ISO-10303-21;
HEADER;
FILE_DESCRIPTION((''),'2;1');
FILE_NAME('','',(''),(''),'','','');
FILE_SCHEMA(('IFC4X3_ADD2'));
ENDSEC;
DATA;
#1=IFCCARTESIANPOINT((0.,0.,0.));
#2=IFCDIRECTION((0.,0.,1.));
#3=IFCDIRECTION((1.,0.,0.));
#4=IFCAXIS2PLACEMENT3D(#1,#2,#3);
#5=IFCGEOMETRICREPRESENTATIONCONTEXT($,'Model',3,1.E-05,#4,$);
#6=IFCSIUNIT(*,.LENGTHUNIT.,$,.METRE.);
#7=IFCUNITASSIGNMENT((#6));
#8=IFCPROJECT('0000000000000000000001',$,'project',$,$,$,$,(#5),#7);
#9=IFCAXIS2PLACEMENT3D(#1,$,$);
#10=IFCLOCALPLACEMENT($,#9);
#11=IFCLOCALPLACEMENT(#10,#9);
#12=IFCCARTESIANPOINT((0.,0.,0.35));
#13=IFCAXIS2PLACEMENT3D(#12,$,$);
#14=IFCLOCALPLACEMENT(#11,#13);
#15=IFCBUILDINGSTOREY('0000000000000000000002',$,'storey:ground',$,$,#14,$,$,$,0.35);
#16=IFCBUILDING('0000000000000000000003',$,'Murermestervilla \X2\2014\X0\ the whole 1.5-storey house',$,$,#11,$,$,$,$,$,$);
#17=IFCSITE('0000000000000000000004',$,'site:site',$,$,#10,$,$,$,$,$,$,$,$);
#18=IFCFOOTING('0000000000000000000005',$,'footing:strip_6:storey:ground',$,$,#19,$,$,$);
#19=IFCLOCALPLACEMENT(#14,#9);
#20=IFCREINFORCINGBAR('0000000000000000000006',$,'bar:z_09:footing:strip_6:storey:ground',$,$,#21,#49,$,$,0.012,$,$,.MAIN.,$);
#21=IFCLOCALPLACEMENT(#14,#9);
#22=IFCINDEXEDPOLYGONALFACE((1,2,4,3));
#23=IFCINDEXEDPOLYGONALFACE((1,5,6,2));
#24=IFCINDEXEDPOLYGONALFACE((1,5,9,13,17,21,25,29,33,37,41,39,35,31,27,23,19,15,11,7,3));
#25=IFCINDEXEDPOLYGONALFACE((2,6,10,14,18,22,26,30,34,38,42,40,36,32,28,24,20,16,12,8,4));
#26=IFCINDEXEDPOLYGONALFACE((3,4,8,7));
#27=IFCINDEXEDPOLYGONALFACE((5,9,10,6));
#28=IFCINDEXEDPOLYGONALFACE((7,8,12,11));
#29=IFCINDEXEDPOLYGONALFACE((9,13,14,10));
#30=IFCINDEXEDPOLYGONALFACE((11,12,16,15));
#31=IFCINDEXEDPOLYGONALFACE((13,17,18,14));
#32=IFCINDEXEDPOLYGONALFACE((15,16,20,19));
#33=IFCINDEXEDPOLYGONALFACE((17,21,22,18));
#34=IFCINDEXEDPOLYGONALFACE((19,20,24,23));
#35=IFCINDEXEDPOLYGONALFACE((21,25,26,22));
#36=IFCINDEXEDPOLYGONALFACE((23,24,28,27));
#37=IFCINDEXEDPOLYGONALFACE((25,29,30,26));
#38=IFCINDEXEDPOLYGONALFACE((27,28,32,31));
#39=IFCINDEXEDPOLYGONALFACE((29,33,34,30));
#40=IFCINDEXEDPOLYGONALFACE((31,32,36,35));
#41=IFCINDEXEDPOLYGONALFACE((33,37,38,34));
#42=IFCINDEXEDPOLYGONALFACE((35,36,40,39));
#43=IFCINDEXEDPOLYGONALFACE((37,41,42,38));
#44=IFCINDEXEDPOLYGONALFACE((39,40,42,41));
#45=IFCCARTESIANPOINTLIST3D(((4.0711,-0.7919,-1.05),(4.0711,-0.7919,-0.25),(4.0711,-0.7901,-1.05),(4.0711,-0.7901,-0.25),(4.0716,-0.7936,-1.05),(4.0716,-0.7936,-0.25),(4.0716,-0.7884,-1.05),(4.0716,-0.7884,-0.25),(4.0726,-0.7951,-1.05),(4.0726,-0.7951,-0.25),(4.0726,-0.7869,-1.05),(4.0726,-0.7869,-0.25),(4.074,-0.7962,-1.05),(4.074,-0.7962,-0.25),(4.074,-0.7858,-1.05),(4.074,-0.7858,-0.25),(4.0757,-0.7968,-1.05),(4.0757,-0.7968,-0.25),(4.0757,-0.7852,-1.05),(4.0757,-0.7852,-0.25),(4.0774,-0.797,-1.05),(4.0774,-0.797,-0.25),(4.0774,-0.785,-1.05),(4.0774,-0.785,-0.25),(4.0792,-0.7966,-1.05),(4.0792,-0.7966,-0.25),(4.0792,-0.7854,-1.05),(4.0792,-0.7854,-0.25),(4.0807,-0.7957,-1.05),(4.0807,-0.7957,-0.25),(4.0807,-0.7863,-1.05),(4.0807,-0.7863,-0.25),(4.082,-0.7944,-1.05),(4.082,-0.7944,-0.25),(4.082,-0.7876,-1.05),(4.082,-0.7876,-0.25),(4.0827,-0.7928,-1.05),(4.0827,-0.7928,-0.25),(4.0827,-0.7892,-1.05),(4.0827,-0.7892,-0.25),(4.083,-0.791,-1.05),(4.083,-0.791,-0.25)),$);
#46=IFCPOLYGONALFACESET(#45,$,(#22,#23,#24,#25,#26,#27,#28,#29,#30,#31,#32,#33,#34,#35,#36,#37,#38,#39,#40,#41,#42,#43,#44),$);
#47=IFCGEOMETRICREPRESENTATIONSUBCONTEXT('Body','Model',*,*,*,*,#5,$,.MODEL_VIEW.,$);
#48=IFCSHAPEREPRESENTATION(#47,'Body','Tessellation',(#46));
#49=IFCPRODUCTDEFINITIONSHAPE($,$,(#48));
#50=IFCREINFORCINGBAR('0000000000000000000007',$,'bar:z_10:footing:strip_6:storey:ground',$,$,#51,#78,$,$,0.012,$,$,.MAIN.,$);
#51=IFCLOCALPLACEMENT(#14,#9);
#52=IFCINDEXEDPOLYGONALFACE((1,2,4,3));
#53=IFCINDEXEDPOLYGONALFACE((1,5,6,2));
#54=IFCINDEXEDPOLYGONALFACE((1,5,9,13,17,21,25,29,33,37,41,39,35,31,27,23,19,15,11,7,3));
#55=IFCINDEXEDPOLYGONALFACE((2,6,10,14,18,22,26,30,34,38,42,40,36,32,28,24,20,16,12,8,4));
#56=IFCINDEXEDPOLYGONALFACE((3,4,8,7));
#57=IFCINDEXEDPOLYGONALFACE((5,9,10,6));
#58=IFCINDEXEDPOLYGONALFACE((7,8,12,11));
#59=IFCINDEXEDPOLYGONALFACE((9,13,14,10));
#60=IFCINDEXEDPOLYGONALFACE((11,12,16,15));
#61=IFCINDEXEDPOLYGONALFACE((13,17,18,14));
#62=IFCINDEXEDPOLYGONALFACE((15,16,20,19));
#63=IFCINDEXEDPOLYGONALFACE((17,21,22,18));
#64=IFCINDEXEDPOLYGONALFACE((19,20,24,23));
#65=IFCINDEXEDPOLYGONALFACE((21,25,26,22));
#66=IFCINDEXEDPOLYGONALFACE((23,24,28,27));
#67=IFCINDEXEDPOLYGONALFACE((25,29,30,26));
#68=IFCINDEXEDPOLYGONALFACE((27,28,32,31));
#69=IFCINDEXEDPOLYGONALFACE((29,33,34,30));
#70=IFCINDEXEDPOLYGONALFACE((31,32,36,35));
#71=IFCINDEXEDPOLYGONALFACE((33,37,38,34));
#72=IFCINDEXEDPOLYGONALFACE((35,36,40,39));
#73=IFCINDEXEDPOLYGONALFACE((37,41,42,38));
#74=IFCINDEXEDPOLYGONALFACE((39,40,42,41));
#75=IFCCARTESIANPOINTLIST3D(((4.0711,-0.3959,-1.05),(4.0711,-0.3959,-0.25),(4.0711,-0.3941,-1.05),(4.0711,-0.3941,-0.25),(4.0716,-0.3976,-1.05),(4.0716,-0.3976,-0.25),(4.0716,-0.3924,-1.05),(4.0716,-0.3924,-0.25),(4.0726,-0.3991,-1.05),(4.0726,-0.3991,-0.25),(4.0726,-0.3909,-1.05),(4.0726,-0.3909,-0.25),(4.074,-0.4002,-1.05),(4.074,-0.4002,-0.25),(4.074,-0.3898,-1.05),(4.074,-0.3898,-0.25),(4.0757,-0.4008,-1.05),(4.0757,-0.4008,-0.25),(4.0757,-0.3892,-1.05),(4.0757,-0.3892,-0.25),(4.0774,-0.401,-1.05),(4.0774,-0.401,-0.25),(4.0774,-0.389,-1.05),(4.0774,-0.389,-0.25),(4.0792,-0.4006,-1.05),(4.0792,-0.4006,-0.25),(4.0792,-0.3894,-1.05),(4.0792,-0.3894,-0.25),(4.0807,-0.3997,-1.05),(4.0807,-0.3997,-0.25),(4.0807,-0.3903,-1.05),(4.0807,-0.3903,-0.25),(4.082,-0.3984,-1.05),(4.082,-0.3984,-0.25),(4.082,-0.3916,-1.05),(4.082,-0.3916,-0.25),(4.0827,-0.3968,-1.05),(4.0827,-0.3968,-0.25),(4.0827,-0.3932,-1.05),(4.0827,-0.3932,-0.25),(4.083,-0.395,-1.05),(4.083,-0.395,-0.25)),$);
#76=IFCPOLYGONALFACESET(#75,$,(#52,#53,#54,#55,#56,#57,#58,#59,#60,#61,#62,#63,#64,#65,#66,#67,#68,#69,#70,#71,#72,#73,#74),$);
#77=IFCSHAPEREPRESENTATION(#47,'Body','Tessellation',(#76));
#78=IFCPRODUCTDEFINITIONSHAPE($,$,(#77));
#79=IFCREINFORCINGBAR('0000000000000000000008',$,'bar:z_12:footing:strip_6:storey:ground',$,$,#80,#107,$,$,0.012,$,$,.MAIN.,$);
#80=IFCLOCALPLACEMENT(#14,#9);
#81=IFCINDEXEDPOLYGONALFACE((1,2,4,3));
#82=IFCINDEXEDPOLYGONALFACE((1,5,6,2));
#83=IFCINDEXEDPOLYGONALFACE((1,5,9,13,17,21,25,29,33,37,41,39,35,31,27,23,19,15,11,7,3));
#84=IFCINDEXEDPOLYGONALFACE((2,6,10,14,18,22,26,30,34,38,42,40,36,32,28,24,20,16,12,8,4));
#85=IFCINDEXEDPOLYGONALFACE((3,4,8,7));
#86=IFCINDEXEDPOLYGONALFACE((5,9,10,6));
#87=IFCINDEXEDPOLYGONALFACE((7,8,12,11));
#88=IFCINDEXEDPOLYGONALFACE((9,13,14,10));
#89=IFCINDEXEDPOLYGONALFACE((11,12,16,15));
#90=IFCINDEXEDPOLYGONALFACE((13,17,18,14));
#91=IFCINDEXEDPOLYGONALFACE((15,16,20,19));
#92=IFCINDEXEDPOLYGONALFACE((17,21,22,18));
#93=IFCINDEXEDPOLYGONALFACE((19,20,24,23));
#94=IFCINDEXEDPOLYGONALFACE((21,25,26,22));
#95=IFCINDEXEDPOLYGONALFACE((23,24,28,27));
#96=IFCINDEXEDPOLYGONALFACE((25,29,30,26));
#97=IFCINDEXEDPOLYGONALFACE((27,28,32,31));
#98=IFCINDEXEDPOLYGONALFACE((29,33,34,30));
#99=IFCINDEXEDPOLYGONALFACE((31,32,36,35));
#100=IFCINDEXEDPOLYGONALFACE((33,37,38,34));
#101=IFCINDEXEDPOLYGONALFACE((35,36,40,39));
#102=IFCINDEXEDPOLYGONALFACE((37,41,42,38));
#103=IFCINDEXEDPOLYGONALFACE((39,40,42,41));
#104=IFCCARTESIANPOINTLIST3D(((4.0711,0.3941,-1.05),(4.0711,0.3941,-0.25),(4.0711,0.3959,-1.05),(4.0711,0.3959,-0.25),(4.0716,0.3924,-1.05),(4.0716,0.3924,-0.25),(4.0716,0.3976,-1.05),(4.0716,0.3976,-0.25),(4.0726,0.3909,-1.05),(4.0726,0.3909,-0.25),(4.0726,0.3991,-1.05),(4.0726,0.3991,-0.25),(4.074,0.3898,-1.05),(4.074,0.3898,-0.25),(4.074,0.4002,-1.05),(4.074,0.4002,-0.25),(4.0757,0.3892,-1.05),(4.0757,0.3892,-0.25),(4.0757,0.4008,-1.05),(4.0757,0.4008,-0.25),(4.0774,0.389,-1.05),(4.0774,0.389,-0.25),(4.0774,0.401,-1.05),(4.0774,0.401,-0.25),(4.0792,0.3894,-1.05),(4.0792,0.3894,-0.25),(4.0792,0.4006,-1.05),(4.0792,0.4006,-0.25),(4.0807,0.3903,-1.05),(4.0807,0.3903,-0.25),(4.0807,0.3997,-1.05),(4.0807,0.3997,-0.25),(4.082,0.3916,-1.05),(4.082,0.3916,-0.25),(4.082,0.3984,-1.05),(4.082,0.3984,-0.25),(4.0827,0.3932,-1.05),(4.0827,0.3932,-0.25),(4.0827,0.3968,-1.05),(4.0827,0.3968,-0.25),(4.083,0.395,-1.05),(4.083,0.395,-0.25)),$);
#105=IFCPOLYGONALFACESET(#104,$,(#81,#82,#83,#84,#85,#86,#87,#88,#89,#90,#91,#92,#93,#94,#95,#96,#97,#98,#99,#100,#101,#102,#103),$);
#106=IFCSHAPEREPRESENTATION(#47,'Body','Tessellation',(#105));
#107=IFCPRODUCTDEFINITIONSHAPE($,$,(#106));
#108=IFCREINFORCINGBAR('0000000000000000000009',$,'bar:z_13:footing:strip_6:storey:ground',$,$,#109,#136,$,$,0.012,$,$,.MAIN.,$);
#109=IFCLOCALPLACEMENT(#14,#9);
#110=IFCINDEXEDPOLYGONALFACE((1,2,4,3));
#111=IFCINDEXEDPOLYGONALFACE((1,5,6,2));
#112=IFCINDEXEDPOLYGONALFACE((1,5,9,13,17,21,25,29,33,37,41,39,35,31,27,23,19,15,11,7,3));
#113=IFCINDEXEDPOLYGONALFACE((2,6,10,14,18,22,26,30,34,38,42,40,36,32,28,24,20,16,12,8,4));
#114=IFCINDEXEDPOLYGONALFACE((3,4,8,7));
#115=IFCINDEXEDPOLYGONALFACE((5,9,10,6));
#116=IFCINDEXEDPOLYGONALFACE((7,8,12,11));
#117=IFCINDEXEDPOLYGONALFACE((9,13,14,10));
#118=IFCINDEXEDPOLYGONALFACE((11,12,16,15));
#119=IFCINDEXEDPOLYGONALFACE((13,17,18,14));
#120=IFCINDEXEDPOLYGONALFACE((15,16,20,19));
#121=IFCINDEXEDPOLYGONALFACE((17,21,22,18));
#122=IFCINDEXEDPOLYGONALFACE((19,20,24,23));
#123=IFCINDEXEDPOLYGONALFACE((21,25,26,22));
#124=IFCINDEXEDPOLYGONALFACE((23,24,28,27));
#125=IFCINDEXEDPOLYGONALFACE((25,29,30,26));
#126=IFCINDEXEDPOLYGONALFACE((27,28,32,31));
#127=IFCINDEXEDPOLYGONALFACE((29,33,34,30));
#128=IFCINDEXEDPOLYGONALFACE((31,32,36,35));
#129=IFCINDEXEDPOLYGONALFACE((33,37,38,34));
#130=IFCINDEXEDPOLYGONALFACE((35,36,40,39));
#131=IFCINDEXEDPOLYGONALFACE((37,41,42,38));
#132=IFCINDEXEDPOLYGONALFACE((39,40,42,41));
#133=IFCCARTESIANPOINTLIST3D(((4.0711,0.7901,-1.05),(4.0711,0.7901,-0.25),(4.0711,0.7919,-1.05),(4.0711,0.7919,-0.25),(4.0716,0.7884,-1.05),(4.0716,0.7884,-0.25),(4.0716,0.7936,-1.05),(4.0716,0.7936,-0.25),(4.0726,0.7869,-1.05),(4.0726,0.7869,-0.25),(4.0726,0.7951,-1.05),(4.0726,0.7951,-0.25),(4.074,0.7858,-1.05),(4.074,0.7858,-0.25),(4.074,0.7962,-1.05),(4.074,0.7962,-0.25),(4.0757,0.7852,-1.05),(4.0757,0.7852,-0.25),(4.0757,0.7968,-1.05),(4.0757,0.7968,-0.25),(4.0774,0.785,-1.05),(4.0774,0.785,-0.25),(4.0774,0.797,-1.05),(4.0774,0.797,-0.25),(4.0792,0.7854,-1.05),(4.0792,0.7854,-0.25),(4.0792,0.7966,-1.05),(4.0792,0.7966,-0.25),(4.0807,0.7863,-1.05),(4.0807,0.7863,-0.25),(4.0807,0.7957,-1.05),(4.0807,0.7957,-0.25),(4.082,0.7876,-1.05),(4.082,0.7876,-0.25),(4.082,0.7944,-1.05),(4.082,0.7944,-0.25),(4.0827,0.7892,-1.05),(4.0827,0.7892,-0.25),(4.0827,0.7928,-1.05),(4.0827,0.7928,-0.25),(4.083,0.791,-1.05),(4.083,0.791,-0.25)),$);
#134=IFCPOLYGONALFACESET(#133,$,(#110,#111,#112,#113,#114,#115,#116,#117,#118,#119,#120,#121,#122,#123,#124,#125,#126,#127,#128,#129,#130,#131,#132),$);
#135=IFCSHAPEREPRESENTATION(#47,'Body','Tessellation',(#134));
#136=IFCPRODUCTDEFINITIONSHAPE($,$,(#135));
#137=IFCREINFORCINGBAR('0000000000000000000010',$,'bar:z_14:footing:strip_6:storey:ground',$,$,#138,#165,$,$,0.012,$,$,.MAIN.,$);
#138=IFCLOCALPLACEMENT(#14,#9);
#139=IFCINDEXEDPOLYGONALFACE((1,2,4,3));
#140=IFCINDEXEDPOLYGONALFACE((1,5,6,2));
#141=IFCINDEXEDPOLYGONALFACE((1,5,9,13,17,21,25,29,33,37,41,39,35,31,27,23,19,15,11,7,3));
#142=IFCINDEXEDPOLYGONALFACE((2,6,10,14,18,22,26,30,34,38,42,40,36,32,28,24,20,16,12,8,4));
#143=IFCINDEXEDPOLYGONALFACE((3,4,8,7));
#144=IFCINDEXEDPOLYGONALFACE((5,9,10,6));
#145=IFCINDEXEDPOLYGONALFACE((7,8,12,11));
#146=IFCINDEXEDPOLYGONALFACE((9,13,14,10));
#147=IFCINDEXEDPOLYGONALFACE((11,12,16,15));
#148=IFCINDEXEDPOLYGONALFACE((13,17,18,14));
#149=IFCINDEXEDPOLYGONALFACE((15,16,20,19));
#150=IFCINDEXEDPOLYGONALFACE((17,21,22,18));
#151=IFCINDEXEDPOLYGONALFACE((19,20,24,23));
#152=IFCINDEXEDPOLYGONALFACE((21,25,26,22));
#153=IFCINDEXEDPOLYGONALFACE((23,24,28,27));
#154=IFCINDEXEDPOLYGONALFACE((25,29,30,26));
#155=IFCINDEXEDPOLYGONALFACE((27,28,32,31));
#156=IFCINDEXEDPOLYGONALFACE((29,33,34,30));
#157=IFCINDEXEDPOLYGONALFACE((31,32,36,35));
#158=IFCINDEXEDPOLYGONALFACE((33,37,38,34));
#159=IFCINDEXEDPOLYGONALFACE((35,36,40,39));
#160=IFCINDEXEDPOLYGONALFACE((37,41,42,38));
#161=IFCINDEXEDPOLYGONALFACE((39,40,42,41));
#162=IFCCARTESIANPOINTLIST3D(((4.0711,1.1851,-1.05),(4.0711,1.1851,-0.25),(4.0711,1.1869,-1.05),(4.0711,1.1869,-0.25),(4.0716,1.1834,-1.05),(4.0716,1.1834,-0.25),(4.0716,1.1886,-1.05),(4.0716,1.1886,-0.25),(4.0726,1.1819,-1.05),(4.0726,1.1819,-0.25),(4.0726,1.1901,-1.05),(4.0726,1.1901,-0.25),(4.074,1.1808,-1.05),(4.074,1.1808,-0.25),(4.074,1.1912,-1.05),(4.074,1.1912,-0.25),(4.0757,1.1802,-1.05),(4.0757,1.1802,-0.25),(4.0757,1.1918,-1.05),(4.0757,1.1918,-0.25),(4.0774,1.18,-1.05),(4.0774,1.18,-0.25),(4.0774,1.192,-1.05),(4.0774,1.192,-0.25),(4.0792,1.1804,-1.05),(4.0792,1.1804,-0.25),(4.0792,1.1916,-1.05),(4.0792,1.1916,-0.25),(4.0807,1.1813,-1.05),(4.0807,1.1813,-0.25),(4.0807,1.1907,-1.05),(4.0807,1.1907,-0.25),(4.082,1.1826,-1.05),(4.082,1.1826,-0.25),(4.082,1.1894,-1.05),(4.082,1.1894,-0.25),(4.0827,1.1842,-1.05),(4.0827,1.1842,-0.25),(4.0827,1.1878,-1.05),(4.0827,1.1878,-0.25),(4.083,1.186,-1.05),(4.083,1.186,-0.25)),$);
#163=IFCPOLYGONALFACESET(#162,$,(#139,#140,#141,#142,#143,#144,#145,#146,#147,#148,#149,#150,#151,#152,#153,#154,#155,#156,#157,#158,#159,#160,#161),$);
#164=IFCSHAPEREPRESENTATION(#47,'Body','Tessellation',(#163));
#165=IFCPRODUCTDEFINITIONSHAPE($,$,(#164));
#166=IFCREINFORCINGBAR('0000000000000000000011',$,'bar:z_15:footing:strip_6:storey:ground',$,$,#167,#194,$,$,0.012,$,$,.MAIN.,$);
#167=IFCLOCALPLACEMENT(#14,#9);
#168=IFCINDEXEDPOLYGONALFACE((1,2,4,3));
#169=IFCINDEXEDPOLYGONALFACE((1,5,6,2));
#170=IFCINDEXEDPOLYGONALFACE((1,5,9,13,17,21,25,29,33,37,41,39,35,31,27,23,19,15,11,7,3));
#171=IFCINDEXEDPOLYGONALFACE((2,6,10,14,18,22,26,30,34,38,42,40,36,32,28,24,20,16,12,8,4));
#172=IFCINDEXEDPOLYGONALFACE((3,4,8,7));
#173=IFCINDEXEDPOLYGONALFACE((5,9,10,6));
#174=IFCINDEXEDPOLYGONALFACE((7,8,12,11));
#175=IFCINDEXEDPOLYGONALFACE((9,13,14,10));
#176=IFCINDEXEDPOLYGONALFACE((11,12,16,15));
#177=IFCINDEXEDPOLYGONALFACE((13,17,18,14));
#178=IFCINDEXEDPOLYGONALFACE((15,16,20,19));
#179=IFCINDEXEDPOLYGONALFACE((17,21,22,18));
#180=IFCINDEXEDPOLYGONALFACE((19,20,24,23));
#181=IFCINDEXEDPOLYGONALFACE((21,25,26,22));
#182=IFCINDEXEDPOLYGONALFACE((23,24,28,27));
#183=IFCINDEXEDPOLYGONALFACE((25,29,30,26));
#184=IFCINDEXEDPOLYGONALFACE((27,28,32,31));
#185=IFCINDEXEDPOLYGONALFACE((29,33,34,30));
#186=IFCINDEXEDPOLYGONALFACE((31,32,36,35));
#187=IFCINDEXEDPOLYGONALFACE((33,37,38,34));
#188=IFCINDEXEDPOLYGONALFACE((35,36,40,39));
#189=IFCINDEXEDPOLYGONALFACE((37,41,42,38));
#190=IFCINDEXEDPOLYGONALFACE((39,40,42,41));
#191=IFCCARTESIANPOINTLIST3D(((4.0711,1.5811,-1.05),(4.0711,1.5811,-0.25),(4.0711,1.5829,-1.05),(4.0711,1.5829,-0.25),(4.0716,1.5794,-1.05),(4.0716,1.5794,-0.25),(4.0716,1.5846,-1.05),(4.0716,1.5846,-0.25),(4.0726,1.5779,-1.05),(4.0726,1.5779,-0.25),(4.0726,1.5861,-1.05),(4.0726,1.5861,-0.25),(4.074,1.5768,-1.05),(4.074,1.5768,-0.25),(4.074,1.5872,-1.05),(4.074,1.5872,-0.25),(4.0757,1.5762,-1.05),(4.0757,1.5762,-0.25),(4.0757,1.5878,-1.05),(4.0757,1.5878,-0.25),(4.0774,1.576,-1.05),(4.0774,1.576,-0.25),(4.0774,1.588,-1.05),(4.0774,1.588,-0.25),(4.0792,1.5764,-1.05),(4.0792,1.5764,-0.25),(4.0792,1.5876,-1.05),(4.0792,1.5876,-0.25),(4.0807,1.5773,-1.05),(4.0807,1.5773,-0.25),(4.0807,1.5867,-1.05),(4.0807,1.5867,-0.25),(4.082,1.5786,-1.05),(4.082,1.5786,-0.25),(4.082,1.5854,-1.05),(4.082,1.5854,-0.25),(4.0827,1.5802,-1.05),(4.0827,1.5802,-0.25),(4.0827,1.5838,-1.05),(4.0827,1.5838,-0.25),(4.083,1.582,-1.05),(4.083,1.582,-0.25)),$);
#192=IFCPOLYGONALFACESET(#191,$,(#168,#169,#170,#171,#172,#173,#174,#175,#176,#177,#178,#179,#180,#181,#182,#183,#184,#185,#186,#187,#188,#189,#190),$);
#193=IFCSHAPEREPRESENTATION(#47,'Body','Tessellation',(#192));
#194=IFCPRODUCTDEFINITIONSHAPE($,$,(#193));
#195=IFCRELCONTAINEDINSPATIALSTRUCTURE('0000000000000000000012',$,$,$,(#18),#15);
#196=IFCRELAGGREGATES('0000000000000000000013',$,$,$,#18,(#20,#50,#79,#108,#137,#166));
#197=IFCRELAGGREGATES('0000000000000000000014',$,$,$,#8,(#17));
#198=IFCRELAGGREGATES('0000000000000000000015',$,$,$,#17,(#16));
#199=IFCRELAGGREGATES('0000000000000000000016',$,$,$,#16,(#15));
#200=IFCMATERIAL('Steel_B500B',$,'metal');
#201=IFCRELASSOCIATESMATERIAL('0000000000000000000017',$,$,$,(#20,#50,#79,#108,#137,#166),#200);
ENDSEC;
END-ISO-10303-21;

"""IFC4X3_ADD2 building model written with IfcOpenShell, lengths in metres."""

from ifc_helpers import new_model, entity, si_unit, frame, origin, origin_with_axes, place, context, subcontext, project, spatial, material, element, aggregate, save


model = new_model("IFC4X3_ADD2")

# Units and contexts
model_context = context("Model", 3, precision=1e-05, world=origin_with_axes())
body_context = subcontext(model_context, "Body", "Model", "MODEL_VIEW")
ifc_project = project(units=[si_unit("LENGTHUNIT", "METRE")], contexts=[model_context])

# Site, building, storey
placement_1 = place(None, origin())
site = spatial("IfcSite", under=ifc_project, at=placement_1, Name="site:site")
building_placement = place(placement_1, origin())
building = spatial("IfcBuilding", under=site, at=building_placement, Name="Murermestervilla — the whole 1.5-storey house")
storey_placement = place(building_placement, frame((0.0, 0.0, 0.35)))
storey = spatial("IfcBuildingStorey", under=building, at=storey_placement, Name="storey:ground", Elevation=0.35)

# Footing, reinforcing bars
placement_2 = place(storey_placement, frame((0.0, 0.0, -0.35)))
footing_1 = element("IfcFooting", 1, at=placement_2, inside=storey, Name="footing:strip_6:storey:ground")
ifc_material = material(Name="Steel_B500B", Category="metal")
reinforcing_bar_1 = element("IfcReinforcingBar", 2, at=placement_1, material=ifc_material, Name="bar:z_09:footing:strip_6:storey:ground", NominalDiameter=0.012, PredefinedType="MAIN", context=body_context, shape_type="AdvancedSweptSolid", body=[
    entity("IfcSweptDiskSolid", entity("IfcPolyline", [entity("IfcCartesianPoint", [4.077, -0.791, -0.7]), entity("IfcCartesianPoint", [4.077, -0.791, 0.1])]), 0.006),
])
reinforcing_bar_2 = element("IfcReinforcingBar", 3, at=placement_1, material=ifc_material, Name="bar:z_10:footing:strip_6:storey:ground", NominalDiameter=0.012, PredefinedType="MAIN", context=body_context, shape_type="AdvancedSweptSolid", body=[
    entity("IfcSweptDiskSolid", entity("IfcPolyline", [entity("IfcCartesianPoint", [4.077, -0.395, -0.7]), entity("IfcCartesianPoint", [4.077, -0.395, 0.1])]), 0.006),
])
reinforcing_bar_3 = element("IfcReinforcingBar", 4, at=placement_1, material=ifc_material, Name="bar:z_12:footing:strip_6:storey:ground", NominalDiameter=0.012, PredefinedType="MAIN", context=body_context, shape_type="AdvancedSweptSolid", body=[
    entity("IfcSweptDiskSolid", entity("IfcPolyline", [entity("IfcCartesianPoint", [4.077, 0.395, -0.7]), entity("IfcCartesianPoint", [4.077, 0.395, 0.1])]), 0.006),
])
reinforcing_bar_4 = element("IfcReinforcingBar", 5, at=placement_1, material=ifc_material, Name="bar:z_13:footing:strip_6:storey:ground", NominalDiameter=0.012, PredefinedType="MAIN", context=body_context, shape_type="AdvancedSweptSolid", body=[
    entity("IfcSweptDiskSolid", entity("IfcPolyline", [entity("IfcCartesianPoint", [4.077, 0.791, -0.7]), entity("IfcCartesianPoint", [4.077, 0.791, 0.1])]), 0.006),
])
reinforcing_bar_5 = element("IfcReinforcingBar", 6, at=placement_1, material=ifc_material, Name="bar:z_14:footing:strip_6:storey:ground", NominalDiameter=0.012, PredefinedType="MAIN", context=body_context, shape_type="AdvancedSweptSolid", body=[
    entity("IfcSweptDiskSolid", entity("IfcPolyline", [entity("IfcCartesianPoint", [4.077, 1.186, -0.7]), entity("IfcCartesianPoint", [4.077, 1.186, 0.1])]), 0.006),
])
reinforcing_bar_6 = element("IfcReinforcingBar", 7, at=placement_1, material=ifc_material, Name="bar:z_15:footing:strip_6:storey:ground", NominalDiameter=0.012, PredefinedType="MAIN", context=body_context, shape_type="AdvancedSweptSolid", body=[
    entity("IfcSweptDiskSolid", entity("IfcPolyline", [entity("IfcCartesianPoint", [4.077, 1.582, -0.7]), entity("IfcCartesianPoint", [4.077, 1.582, 0.1])]), 0.006),
])
aggregate(footing_1, [reinforcing_bar_1, reinforcing_bar_2, reinforcing_bar_3, reinforcing_bar_4, reinforcing_bar_5, reinforcing_bar_6])

save(model, "model.ifc")
